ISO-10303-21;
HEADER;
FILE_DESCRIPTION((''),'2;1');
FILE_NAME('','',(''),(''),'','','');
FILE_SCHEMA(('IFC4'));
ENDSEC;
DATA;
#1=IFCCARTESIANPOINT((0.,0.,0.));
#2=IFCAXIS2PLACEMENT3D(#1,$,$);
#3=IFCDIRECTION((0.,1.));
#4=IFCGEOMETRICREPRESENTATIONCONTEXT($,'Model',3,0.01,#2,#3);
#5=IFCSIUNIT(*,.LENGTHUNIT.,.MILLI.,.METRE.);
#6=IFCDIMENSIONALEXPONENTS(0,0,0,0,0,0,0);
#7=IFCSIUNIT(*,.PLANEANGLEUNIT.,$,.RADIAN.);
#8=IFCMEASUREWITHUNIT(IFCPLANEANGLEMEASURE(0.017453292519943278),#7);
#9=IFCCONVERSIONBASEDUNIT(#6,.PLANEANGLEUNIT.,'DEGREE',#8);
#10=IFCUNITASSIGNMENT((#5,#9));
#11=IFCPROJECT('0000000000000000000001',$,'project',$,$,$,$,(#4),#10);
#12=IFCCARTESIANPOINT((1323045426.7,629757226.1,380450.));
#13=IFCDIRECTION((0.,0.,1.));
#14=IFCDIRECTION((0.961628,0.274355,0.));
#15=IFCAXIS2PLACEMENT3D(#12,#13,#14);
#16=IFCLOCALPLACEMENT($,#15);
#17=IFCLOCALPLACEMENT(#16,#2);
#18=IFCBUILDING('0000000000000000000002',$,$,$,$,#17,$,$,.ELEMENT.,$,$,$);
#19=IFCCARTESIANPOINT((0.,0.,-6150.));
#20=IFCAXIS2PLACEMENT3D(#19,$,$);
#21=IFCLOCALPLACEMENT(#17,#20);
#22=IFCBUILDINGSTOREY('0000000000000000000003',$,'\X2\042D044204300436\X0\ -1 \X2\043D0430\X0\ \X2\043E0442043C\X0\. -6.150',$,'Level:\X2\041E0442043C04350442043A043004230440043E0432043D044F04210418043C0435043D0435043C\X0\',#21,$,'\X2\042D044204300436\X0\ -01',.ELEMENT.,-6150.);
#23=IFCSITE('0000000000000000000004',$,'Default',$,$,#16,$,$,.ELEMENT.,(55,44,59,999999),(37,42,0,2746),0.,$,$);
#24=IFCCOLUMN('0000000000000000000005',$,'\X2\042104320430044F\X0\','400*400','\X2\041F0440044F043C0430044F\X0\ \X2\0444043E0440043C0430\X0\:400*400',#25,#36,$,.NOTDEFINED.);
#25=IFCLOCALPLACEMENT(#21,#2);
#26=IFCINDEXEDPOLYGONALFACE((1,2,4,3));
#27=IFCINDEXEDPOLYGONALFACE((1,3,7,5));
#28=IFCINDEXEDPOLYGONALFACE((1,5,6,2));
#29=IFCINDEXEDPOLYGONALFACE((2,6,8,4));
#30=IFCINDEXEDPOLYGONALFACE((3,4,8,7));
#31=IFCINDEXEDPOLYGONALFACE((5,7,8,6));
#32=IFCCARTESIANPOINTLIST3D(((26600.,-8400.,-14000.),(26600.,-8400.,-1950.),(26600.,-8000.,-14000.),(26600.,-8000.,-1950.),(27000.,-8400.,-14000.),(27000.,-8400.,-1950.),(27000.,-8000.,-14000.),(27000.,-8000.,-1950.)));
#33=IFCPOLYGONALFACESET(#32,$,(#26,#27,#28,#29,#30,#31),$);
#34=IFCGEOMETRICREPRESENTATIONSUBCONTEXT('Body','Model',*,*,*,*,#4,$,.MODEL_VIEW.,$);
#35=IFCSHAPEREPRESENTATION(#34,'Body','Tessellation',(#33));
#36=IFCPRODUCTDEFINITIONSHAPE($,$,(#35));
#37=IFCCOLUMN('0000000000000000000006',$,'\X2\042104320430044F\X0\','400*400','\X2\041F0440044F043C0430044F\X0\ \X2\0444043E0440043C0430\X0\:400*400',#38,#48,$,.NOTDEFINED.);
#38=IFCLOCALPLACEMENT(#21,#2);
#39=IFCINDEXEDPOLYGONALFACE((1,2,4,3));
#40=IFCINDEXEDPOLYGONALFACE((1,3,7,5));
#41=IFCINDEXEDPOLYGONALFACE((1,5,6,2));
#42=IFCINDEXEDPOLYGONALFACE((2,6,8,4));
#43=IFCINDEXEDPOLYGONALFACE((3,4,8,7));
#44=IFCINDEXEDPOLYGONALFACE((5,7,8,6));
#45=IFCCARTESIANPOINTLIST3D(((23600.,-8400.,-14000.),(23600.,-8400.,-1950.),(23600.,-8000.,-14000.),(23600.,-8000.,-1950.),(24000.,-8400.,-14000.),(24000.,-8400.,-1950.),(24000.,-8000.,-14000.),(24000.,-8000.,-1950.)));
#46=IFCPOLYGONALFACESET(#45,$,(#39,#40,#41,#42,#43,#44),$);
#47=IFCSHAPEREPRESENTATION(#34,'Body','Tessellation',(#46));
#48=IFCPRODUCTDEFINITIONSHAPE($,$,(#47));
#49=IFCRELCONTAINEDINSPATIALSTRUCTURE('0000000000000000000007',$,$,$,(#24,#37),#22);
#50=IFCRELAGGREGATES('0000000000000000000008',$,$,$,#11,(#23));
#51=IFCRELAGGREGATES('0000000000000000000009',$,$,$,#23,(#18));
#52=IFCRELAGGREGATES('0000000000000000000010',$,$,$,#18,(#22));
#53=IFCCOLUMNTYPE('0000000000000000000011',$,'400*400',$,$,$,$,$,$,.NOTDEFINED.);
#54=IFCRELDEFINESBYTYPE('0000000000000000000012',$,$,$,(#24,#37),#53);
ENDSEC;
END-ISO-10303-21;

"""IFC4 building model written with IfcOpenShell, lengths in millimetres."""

from ifc_helpers import new_model, entity, si_unit, converted_unit, direction, frame, origin, place, context, subcontext, project, spatial, indexed_curve, outline, extrude, type_object, element, save


model = new_model("IFC4")

# Units and contexts
model_context = context("Model", 3, precision=0.01, world=origin(), true_north=direction((0.0, 1.0)))
body_context = subcontext(model_context, "Body", "Model", "MODEL_VIEW")
ifc_project = project(units=[si_unit("LENGTHUNIT", "METRE", prefix="MILLI"), converted_unit("PLANEANGLEUNIT", "DEGREE", entity("IfcPlaneAngleMeasure", 0.017453292519943278), si_unit("PLANEANGLEUNIT", "RADIAN"), dimensions=[0, 0, 0, 0, 0, 0, 0])], contexts=[model_context])

# Site, building, storey
site_placement = place(None, frame((1323045426.7, 629757226.1, 380450.0), z_axis=(0.0, 0.0, 1.0), x_axis=(0.961628, 0.274355, 0.0)))
site = spatial("IfcSite", under=ifc_project, at=site_placement, Name="Default", CompositionType="ELEMENT", RefLatitude=(55, 44, 59, 999999), RefLongitude=(37, 42, 0, 2746), RefElevation=0.0)
building_placement = place(site_placement, origin())
building = spatial("IfcBuilding", under=site, at=building_placement, CompositionType="ELEMENT")
storey_placement = place(building_placement, frame((0.0, 0.0, -6150.0)))
storey = spatial("IfcBuildingStorey", under=building, at=storey_placement, Name="Этаж -1 на отм. -6.150", ObjectType="Level:ОтметкаУровняСИменем", LongName="Этаж -01", CompositionType="ELEMENT", Elevation=-6150.0)

# Columns
column_type = type_object("IfcColumnType", Name="400*400", PredefinedType="NOTDEFINED")
column_1_placement = place(storey_placement, origin())
element("IfcColumn", 1, at=column_1_placement, inside=storey, type_object=column_type, Name="Свая", Description="400*400", ObjectType="Прямая форма:400*400", PredefinedType="NOTDEFINED", context=body_context, shape_type="SweptSolid", body=[
    extrude(outline(indexed_curve([(-200.0, -200.0), (200.0, -200.0), (200.0, 200.0), (-200.0, 200.0), (-200.0, -200.0)], self_intersect=False)), frame((26800.0, -8200.0, -14000.0), z_axis=(0.0, 0.0, 1.0), x_axis=(0.0, 1.0, 0.0)), (0.0, 0.0, 1.0), 12050.0),
])
column_2_placement = place(storey_placement, origin())
element("IfcColumn", 2, at=column_2_placement, inside=storey, type_object=column_type, Name="Свая", Description="400*400", ObjectType="Прямая форма:400*400", PredefinedType="NOTDEFINED", context=body_context, shape_type="SweptSolid", body=[
    extrude(outline(indexed_curve([(-200.0, -200.0), (200.0, -200.0), (200.0, 200.0), (-200.0, 200.0), (-200.0, -200.0)], self_intersect=False)), frame((23800.0, -8200.0, -14000.0), z_axis=(0.0, 0.0, 1.0), x_axis=(0.0, 1.0, 0.0)), (0.0, 0.0, 1.0), 12050.0),
])

save(model, "model.ifc")
